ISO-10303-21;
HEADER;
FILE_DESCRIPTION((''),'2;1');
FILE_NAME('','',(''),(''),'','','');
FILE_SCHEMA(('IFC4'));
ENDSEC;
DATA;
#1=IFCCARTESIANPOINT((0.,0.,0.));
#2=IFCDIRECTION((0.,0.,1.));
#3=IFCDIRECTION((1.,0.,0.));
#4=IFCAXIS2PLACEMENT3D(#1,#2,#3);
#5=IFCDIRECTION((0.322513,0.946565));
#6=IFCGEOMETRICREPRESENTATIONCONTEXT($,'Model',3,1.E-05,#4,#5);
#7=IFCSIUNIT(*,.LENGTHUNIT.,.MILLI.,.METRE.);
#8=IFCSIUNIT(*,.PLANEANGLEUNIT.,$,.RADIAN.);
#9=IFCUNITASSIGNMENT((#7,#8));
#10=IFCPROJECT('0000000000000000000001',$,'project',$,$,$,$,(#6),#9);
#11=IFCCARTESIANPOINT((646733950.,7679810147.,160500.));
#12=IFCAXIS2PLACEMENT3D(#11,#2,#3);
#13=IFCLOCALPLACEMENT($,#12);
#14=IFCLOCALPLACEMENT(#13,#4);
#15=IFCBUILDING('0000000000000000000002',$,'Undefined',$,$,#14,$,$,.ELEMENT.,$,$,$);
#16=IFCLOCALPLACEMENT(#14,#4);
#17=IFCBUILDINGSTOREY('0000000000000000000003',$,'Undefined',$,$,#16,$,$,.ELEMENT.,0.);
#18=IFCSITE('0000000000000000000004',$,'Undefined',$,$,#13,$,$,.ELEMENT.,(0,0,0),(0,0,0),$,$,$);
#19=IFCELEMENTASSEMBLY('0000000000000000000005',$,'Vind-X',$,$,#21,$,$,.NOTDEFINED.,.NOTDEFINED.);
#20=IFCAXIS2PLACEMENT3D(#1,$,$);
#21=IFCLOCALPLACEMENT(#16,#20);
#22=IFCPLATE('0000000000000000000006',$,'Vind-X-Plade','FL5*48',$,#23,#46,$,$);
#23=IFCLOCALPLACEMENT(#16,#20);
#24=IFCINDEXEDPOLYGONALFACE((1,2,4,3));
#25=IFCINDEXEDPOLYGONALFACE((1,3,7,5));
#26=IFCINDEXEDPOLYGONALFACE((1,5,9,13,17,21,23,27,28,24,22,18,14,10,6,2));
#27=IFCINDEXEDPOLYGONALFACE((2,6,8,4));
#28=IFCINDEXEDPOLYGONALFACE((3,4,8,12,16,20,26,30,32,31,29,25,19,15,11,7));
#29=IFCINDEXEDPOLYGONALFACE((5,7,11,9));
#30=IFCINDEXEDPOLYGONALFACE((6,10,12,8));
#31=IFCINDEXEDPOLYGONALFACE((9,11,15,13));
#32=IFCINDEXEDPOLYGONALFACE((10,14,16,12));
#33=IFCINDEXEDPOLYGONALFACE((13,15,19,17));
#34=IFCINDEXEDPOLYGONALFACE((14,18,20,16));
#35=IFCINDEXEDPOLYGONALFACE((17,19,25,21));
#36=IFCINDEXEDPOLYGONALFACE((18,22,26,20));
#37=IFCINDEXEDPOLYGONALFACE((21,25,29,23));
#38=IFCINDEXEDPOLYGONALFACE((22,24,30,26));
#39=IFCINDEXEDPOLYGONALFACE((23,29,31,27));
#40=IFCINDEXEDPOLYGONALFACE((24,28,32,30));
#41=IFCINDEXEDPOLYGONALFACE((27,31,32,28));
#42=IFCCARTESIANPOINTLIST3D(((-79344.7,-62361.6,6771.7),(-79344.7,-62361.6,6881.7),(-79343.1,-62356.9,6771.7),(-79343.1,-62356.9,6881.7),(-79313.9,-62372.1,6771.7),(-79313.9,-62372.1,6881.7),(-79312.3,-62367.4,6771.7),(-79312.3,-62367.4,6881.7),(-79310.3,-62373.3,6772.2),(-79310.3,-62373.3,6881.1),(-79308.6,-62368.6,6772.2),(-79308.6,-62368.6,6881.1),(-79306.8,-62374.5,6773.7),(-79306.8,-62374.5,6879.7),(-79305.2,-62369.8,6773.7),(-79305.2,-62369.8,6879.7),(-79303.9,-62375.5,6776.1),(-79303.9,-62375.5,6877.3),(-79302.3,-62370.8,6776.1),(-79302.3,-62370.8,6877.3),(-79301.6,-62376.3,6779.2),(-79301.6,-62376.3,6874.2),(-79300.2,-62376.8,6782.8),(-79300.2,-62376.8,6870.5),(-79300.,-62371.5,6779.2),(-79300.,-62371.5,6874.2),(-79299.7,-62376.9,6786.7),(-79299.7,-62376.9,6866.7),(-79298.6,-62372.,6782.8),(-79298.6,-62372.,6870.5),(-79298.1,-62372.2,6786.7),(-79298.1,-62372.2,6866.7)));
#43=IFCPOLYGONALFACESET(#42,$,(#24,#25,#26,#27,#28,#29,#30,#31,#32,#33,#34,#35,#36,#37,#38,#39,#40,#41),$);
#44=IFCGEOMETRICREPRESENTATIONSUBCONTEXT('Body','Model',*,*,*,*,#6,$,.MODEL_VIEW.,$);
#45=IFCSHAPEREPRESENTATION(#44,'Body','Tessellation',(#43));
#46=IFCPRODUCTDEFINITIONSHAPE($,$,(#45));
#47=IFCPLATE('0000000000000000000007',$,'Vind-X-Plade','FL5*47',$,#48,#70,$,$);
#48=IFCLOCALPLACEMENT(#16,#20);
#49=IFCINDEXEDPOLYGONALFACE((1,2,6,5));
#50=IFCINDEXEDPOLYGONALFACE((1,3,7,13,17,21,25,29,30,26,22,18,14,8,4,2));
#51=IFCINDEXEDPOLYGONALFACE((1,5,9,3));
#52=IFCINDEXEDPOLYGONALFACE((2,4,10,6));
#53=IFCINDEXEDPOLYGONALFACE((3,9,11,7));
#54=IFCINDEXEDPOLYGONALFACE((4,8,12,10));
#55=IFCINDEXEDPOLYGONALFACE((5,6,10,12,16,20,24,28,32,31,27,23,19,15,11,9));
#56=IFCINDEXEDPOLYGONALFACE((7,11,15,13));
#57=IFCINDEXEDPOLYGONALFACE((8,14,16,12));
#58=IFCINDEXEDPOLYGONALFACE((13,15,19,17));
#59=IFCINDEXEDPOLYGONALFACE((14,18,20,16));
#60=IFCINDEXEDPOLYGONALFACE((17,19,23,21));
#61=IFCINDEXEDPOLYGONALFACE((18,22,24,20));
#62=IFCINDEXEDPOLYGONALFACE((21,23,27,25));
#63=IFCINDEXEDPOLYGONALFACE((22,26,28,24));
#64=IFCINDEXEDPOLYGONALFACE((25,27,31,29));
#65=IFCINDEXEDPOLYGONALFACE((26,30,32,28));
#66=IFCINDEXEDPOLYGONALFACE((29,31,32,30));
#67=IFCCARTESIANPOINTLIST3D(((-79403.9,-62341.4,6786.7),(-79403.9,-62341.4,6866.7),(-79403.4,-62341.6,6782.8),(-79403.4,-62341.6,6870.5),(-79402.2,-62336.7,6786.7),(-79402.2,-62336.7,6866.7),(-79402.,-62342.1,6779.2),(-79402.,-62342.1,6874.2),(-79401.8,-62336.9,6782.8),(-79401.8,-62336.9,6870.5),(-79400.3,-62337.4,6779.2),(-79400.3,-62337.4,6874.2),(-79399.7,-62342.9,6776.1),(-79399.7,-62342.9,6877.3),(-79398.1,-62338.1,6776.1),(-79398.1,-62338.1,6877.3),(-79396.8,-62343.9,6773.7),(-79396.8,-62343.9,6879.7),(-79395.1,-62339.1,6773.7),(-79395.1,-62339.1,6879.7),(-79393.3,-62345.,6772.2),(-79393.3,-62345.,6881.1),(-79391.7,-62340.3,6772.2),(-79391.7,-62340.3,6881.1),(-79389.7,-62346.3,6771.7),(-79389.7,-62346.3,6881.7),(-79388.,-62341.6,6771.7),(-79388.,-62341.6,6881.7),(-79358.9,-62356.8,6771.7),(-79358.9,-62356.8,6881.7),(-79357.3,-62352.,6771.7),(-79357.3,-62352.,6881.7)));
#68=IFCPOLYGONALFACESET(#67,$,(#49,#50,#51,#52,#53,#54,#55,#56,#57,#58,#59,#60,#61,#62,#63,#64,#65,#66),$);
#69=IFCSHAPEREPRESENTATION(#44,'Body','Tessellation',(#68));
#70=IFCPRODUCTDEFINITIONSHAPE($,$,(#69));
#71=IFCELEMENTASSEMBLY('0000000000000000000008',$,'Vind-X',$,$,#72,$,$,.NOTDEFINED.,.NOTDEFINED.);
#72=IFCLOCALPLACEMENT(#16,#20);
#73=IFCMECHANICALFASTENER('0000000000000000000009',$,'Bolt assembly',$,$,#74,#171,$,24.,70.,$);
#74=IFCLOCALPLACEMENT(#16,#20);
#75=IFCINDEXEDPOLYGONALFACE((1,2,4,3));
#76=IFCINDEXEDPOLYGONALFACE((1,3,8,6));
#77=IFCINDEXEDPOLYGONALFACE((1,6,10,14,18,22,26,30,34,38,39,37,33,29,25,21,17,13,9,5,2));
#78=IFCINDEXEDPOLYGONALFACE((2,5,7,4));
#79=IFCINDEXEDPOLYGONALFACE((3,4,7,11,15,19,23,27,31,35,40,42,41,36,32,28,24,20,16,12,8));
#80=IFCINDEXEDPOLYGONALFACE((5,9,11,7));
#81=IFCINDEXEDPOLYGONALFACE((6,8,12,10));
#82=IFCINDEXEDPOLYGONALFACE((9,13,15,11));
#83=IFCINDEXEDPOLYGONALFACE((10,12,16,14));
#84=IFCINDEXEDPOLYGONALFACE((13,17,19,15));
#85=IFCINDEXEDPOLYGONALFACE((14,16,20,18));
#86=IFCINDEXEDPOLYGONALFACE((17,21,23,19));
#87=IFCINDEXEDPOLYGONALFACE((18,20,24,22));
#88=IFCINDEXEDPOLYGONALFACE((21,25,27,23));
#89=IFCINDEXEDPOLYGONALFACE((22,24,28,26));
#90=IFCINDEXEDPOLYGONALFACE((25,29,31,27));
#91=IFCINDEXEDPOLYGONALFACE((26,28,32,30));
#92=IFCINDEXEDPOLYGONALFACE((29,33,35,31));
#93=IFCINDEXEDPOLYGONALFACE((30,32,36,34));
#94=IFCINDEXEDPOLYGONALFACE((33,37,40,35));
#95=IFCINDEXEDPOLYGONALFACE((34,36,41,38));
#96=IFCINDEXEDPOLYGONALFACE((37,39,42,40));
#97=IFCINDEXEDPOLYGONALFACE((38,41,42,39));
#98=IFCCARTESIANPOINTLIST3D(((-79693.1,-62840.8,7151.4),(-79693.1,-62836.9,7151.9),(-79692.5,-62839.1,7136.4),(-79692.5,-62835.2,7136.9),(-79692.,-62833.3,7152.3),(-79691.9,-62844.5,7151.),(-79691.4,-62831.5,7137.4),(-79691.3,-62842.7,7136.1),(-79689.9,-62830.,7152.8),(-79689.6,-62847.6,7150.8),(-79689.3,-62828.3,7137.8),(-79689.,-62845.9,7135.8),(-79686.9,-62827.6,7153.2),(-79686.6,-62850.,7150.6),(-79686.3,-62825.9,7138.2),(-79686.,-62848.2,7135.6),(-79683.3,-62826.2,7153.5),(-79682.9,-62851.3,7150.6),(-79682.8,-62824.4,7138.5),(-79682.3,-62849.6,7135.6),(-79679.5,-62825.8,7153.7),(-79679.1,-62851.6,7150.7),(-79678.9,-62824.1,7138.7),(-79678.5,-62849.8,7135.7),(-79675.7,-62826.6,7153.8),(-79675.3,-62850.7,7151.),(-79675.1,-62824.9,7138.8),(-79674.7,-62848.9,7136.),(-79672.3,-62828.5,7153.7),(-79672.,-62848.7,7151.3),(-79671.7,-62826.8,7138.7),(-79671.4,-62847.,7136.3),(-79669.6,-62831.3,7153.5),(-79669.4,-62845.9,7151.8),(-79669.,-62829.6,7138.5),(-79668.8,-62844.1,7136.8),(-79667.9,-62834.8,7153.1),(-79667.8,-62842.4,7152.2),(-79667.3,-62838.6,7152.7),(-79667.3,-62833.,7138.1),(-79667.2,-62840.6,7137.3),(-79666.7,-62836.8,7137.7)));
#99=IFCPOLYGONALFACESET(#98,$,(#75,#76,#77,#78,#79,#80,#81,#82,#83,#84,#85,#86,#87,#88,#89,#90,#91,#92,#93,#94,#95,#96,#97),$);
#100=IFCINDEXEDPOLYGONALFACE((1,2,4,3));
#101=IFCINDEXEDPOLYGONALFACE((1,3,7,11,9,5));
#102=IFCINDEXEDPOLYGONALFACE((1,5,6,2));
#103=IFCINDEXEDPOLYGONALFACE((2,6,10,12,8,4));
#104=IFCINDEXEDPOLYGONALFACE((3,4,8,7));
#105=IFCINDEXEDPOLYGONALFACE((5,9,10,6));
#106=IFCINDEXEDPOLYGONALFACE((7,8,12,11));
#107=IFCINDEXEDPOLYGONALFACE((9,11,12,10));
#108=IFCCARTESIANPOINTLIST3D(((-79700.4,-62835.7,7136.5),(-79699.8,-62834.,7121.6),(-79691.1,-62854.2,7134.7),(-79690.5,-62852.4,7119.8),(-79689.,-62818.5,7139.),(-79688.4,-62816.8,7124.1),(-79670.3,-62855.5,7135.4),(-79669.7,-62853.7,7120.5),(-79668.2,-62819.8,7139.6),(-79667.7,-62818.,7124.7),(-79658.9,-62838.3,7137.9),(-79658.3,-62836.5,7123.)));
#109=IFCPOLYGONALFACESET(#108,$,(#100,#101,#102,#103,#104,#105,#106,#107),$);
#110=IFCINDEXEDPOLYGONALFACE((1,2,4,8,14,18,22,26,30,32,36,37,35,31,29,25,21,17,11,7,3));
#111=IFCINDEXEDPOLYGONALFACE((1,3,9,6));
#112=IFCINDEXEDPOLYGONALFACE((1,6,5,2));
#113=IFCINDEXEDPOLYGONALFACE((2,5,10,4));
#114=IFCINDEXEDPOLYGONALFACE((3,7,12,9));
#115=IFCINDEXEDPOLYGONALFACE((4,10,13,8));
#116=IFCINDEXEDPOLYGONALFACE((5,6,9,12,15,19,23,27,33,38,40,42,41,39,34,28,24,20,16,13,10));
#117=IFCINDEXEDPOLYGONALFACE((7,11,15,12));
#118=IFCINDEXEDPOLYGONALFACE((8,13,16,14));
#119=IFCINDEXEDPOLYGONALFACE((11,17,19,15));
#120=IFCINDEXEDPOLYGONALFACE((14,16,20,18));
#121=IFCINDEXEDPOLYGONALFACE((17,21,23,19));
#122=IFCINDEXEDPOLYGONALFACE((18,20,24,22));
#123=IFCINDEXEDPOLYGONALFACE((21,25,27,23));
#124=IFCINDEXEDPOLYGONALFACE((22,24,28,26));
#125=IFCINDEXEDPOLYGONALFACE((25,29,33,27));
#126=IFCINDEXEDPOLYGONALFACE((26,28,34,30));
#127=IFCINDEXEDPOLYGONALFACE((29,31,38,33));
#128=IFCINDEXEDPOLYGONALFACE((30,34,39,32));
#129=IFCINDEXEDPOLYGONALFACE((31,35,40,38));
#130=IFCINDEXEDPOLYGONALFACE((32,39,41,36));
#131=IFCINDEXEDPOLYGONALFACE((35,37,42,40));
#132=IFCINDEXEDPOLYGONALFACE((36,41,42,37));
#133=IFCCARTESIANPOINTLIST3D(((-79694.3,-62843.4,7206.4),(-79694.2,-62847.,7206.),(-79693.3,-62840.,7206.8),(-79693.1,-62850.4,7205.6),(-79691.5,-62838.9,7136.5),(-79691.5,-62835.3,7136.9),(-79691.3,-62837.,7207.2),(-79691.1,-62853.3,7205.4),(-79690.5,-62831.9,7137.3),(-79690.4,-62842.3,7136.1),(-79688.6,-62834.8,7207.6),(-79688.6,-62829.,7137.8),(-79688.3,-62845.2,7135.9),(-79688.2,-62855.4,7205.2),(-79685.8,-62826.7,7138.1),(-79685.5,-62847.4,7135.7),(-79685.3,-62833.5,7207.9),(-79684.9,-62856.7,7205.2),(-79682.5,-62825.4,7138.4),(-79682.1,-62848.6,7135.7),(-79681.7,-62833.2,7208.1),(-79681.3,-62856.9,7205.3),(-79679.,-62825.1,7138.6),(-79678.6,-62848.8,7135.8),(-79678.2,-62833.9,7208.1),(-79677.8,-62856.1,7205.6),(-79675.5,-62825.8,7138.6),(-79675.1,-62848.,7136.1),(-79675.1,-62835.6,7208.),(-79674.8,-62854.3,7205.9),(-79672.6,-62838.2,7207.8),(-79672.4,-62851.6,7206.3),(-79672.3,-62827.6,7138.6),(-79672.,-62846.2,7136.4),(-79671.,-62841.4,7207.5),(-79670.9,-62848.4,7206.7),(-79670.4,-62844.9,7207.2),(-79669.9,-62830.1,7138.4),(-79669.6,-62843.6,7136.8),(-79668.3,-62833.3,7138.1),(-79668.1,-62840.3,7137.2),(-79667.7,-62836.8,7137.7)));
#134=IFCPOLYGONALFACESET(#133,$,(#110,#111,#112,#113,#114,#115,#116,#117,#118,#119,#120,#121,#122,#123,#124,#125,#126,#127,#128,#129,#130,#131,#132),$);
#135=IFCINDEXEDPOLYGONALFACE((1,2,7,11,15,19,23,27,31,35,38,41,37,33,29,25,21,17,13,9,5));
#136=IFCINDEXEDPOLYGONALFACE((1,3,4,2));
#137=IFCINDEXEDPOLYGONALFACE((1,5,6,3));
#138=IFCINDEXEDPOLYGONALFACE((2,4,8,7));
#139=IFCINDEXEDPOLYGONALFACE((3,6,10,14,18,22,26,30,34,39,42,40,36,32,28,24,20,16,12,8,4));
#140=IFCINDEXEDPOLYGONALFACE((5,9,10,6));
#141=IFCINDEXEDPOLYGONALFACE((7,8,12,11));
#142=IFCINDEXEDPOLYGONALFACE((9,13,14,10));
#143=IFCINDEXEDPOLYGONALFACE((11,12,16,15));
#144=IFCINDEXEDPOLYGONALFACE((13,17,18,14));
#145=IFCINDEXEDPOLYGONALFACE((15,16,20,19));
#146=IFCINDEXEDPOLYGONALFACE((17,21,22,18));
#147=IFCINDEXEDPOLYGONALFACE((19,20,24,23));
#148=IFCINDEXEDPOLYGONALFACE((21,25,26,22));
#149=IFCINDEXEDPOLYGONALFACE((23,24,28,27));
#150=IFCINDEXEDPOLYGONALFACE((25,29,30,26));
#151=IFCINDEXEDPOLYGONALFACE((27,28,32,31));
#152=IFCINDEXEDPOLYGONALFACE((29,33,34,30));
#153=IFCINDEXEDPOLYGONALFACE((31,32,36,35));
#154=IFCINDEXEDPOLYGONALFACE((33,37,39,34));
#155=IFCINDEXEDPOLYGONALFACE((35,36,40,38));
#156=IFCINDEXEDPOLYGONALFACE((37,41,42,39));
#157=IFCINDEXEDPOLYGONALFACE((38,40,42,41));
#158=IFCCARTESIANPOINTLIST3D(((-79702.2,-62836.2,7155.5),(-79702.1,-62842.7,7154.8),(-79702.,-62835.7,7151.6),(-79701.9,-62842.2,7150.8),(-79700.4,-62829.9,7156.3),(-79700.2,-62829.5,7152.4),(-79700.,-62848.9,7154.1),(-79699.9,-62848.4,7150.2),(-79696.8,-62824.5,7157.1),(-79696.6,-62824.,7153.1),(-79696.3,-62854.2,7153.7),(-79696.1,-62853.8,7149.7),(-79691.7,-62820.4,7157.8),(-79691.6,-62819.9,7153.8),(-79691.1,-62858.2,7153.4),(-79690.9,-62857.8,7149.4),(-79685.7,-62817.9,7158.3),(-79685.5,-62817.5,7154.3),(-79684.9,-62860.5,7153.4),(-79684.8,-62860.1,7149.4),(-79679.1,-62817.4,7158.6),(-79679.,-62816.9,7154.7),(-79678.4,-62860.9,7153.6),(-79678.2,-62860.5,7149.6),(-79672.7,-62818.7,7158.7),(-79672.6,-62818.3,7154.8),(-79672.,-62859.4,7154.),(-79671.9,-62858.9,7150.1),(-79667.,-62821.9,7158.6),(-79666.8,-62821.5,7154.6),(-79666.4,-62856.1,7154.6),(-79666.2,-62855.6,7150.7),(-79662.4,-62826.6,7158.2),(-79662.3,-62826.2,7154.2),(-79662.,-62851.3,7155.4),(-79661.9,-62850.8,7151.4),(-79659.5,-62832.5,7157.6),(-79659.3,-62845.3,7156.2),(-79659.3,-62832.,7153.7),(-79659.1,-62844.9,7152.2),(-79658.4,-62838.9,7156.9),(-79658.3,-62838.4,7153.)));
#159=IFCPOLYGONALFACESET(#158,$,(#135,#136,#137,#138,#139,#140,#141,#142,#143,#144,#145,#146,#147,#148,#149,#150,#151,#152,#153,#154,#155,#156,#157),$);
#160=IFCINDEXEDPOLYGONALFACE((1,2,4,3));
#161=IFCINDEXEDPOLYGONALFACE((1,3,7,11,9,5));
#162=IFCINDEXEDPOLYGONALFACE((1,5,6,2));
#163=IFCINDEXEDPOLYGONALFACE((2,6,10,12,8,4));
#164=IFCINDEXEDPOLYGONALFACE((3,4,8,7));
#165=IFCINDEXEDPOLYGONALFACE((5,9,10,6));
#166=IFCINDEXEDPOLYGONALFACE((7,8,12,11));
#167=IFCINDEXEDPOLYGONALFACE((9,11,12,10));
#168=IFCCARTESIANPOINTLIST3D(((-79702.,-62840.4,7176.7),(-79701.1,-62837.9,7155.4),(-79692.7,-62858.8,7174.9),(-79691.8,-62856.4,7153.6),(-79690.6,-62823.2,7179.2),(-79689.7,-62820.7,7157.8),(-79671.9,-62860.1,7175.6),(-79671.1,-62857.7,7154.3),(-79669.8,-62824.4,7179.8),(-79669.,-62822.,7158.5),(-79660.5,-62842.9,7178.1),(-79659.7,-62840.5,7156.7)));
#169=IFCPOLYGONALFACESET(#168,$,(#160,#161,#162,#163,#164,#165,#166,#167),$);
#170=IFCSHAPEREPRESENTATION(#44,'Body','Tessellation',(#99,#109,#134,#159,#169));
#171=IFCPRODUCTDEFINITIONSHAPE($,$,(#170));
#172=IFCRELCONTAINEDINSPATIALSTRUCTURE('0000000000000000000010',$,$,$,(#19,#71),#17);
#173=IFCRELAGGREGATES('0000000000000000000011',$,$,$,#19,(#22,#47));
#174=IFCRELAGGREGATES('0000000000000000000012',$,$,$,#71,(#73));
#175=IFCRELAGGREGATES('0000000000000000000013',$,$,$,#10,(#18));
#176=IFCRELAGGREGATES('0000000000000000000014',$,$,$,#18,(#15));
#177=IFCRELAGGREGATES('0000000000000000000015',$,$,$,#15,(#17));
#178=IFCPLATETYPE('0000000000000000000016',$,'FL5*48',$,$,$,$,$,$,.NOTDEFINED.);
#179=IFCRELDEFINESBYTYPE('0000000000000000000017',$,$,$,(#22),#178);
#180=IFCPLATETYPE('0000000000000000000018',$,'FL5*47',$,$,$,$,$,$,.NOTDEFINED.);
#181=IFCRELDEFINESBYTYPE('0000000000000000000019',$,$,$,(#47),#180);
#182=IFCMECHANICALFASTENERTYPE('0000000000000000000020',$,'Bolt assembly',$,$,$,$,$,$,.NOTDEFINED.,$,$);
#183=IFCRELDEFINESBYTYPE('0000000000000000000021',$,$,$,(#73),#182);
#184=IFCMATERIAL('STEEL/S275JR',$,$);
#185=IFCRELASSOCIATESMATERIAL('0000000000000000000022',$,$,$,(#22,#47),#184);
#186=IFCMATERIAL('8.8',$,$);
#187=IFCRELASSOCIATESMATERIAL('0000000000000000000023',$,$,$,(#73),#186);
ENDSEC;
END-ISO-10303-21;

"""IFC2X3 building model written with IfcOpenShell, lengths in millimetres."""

from ifc_helpers import new_model, si_unit, direction, frame, frame_2d, origin_with_axes, origin_2d_with_axis, place, context, subcontext, project, spatial, polyline, circle_curve, parameter, trimmed, segment, composite_curve, circle, outline, extrude, source, transform, mapped, material, type_object, element, aggregate, save


model = new_model("IFC2X3")

# Units and contexts
model_context = context("Model", 3, precision=1e-05, world=origin_with_axes(), true_north=direction((0.322513, 0.946565)))
body_context = subcontext(model_context, "Body", "Model", "MODEL_VIEW")
ifc_project = project(units=[si_unit("LENGTHUNIT", "METRE", prefix="MILLI"), si_unit("PLANEANGLEUNIT", "RADIAN")], contexts=[model_context])

# Site, building, storey
site_placement = place(None, frame((646733950.0, 7679810147.0, 160500.0), z_axis=(0.0, 0.0, 1.0), x_axis=(1.0, 0.0, 0.0)))
site = spatial("IfcSite", under=ifc_project, at=site_placement, Name="Undefined", CompositionType="ELEMENT", RefLatitude=(0, 0, 0), RefLongitude=(0, 0, 0))
building_placement = place(site_placement, origin_with_axes())
building = spatial("IfcBuilding", under=site, at=building_placement, Name="Undefined", CompositionType="ELEMENT")
storey_placement = place(building_placement, origin_with_axes())
storey = spatial("IfcBuildingStorey", under=building, at=storey_placement, Name="Undefined", CompositionType="ELEMENT", Elevation=0.0)

# Shared definitions
ifc_material_1 = material(Name="STEEL/S275JR")

# Element assembly
assembly_1_placement = place(storey_placement, origin_with_axes())
assembly_1 = element("IfcElementAssembly", 1, at=assembly_1_placement, inside=storey, Name="Vind-X", AssemblyPlace="NOTDEFINED", PredefinedType="NOTDEFINED")

# Plates
plate_type_1 = type_object("IfcPlateType", Name="FL5*48", PredefinedType="NOTDEFINED")
plate_1_placement = place(assembly_1_placement, frame((-79298.9, -62374.6, 6771.7), z_axis=(0.322513, 0.946565, 0.0), x_axis=(-0.946565, 0.322513, 0.0)))
plate_1 = element("IfcPlate", 2, at=plate_1_placement, type_object=plate_type_1, material=ifc_material_1, Name="Vind-X-Plade", Description="FL5*48", context=body_context, shape_type="SweptSolid", body=[
    extrude(outline(composite_curve([segment(trimmed(circle_curve(frame_2d((15.0, 15.0), x_axis=(-1.0, 0.0)), 15.0), [parameter(0.0)], [parameter(1.570796)], True, "PARAMETER"), True, "CONTINUOUS"), segment(polyline([(15.0, 0.0), (47.5, 0.0), (47.5, 110.0), (15.0, 110.0)]), True, "CONTINUOUS"), segment(trimmed(circle_curve(frame_2d((15.0, 95.0), x_axis=(0.0, 1.0)), 15.0), [parameter(0.0)], [parameter(1.570796)], True, "PARAMETER"), True, "CONTINUOUS"), segment(polyline([(0.0, 95.0), (0.0, 15.0)]), True, "CONTINUOUS")], self_intersect=True)), frame((0.0, 0.0, -2.5), z_axis=(0.0, 0.0, 1.0), x_axis=(1.0, 0.0, 0.0)), (0.0, 0.0, 1.0), 5.0),
])
plate_type_2 = type_object("IfcPlateType", Name="FL5*47", PredefinedType="NOTDEFINED")
plate_2_placement = place(assembly_1_placement, frame((-79358.1, -62354.4, 6771.7), z_axis=(0.322513, 0.946565, 0.0), x_axis=(-0.946565, 0.322513, 0.0)))
plate_2 = element("IfcPlate", 3, at=plate_2_placement, type_object=plate_type_2, material=ifc_material_1, Name="Vind-X-Plade", Description="FL5*47", context=body_context, shape_type="SweptSolid", body=[
    extrude(outline(composite_curve([segment(polyline([(0.0, 0.0), (32.5, 0.0)]), True, "CONTINUOUS"), segment(trimmed(circle_curve(frame_2d((32.5, 15.0), x_axis=(0.0, -1.0)), 15.0), [parameter(0.0)], [parameter(1.570796)], True, "PARAMETER"), True, "CONTINUOUS"), segment(polyline([(47.5, 15.0), (47.5, 95.0)]), True, "CONTINUOUS"), segment(trimmed(circle_curve(frame_2d((32.5, 95.0), x_axis=(1.0, 0.0)), 15.0), [parameter(0.0)], [parameter(1.570796)], True, "PARAMETER"), True, "CONTINUOUS"), segment(polyline([(32.5, 110.0), (0.0, 110.0), (0.0, 0.0)]), True, "CONTINUOUS")], self_intersect=True)), frame((0.0, 0.0, -2.5), z_axis=(0.0, 0.0, 1.0), x_axis=(1.0, 0.0, 0.0)), (0.0, 0.0, 1.0), 5.0),
])
aggregate(assembly_1, [plate_1, plate_2])

# Shared definitions
ifc_material_2 = material(Name="8.8")
mechanical_fastener_type = type_object("IfcMechanicalFastenerType", Name="Bolt assembly")

# Element assembly, mechanical fastener
assembly_2_placement = place(storey_placement, origin_with_axes())
assembly_2 = element("IfcElementAssembly", 4, at=assembly_2_placement, inside=storey, Name="Vind-X", AssemblyPlace="NOTDEFINED", PredefinedType="NOTDEFINED")
shared_shape_1 = source(origin_with_axes(), body_context, "Body", "SweptSolid", [
    extrude(circle(Radius=13.0, at=origin_2d_with_axis()), frame((0.0, 0.0, 0.0), z_axis=(0.0, 1.0, 0.0), x_axis=(1.0, 0.0, 0.0)), (0.0, 0.0, 1.0), 15.1),
    extrude(outline(polyline([(18.0, -10.4), (18.0, 10.4), (0.0, 20.8), (-18.0, 10.4), (-18.0, -10.4), (0.0, -20.8), (18.0, -10.4)])), frame((0.0, -15.0, 0.0), z_axis=(0.0, 1.0, 0.0), x_axis=(1.0, 0.0, 0.0)), (0.0, 0.0, 1.0), 15.0),
    extrude(circle(Radius=12.0, at=origin_2d_with_axis()), frame((0.0, 0.0, 0.0), z_axis=(0.0, 1.0, 0.0), x_axis=(1.0, 0.0, 0.0)), (0.0, 0.0, 1.0), 70.0),
    extrude(circle(Radius=22.0, at=origin_2d_with_axis()), frame((0.0, 15.0, 0.0), z_axis=(0.0, 1.0, 0.0), x_axis=(1.0, 0.0, 0.0)), (0.0, 0.0, 1.0), 4.0),
    extrude(outline(polyline([(18.0, -10.4), (18.0, 10.4), (0.0, 20.8), (-18.0, 10.4), (-18.0, -10.4), (0.0, -20.8), (18.0, -10.4)])), frame((0.0, 19.0, 0.0), z_axis=(0.0, 1.0, 0.0), x_axis=(1.0, 0.0, 0.0)), (0.0, 0.0, 1.0), 21.5),
])
mechanical_fastener_1_placement = place(assembly_2_placement, frame((-79679.7, -62837.0, 7137.2), z_axis=(-0.448662, 0.88959, 0.085625), x_axis=(-0.892837, -0.441952, -0.086721)))
mechanical_fastener_1 = element("IfcMechanicalFastener", 5, at=mechanical_fastener_1_placement, type_object=mechanical_fastener_type, material=ifc_material_2, Name="Bolt assembly", NominalDiameter=24.0, NominalLength=70.0, context=body_context, shape_type="MappedRepresentation", body=[
    mapped(shared_shape_1, transform((0.0, 0.0, 0.0))),
])
aggregate(assembly_2, [mechanical_fastener_1])

save(model, "model.ifc")
